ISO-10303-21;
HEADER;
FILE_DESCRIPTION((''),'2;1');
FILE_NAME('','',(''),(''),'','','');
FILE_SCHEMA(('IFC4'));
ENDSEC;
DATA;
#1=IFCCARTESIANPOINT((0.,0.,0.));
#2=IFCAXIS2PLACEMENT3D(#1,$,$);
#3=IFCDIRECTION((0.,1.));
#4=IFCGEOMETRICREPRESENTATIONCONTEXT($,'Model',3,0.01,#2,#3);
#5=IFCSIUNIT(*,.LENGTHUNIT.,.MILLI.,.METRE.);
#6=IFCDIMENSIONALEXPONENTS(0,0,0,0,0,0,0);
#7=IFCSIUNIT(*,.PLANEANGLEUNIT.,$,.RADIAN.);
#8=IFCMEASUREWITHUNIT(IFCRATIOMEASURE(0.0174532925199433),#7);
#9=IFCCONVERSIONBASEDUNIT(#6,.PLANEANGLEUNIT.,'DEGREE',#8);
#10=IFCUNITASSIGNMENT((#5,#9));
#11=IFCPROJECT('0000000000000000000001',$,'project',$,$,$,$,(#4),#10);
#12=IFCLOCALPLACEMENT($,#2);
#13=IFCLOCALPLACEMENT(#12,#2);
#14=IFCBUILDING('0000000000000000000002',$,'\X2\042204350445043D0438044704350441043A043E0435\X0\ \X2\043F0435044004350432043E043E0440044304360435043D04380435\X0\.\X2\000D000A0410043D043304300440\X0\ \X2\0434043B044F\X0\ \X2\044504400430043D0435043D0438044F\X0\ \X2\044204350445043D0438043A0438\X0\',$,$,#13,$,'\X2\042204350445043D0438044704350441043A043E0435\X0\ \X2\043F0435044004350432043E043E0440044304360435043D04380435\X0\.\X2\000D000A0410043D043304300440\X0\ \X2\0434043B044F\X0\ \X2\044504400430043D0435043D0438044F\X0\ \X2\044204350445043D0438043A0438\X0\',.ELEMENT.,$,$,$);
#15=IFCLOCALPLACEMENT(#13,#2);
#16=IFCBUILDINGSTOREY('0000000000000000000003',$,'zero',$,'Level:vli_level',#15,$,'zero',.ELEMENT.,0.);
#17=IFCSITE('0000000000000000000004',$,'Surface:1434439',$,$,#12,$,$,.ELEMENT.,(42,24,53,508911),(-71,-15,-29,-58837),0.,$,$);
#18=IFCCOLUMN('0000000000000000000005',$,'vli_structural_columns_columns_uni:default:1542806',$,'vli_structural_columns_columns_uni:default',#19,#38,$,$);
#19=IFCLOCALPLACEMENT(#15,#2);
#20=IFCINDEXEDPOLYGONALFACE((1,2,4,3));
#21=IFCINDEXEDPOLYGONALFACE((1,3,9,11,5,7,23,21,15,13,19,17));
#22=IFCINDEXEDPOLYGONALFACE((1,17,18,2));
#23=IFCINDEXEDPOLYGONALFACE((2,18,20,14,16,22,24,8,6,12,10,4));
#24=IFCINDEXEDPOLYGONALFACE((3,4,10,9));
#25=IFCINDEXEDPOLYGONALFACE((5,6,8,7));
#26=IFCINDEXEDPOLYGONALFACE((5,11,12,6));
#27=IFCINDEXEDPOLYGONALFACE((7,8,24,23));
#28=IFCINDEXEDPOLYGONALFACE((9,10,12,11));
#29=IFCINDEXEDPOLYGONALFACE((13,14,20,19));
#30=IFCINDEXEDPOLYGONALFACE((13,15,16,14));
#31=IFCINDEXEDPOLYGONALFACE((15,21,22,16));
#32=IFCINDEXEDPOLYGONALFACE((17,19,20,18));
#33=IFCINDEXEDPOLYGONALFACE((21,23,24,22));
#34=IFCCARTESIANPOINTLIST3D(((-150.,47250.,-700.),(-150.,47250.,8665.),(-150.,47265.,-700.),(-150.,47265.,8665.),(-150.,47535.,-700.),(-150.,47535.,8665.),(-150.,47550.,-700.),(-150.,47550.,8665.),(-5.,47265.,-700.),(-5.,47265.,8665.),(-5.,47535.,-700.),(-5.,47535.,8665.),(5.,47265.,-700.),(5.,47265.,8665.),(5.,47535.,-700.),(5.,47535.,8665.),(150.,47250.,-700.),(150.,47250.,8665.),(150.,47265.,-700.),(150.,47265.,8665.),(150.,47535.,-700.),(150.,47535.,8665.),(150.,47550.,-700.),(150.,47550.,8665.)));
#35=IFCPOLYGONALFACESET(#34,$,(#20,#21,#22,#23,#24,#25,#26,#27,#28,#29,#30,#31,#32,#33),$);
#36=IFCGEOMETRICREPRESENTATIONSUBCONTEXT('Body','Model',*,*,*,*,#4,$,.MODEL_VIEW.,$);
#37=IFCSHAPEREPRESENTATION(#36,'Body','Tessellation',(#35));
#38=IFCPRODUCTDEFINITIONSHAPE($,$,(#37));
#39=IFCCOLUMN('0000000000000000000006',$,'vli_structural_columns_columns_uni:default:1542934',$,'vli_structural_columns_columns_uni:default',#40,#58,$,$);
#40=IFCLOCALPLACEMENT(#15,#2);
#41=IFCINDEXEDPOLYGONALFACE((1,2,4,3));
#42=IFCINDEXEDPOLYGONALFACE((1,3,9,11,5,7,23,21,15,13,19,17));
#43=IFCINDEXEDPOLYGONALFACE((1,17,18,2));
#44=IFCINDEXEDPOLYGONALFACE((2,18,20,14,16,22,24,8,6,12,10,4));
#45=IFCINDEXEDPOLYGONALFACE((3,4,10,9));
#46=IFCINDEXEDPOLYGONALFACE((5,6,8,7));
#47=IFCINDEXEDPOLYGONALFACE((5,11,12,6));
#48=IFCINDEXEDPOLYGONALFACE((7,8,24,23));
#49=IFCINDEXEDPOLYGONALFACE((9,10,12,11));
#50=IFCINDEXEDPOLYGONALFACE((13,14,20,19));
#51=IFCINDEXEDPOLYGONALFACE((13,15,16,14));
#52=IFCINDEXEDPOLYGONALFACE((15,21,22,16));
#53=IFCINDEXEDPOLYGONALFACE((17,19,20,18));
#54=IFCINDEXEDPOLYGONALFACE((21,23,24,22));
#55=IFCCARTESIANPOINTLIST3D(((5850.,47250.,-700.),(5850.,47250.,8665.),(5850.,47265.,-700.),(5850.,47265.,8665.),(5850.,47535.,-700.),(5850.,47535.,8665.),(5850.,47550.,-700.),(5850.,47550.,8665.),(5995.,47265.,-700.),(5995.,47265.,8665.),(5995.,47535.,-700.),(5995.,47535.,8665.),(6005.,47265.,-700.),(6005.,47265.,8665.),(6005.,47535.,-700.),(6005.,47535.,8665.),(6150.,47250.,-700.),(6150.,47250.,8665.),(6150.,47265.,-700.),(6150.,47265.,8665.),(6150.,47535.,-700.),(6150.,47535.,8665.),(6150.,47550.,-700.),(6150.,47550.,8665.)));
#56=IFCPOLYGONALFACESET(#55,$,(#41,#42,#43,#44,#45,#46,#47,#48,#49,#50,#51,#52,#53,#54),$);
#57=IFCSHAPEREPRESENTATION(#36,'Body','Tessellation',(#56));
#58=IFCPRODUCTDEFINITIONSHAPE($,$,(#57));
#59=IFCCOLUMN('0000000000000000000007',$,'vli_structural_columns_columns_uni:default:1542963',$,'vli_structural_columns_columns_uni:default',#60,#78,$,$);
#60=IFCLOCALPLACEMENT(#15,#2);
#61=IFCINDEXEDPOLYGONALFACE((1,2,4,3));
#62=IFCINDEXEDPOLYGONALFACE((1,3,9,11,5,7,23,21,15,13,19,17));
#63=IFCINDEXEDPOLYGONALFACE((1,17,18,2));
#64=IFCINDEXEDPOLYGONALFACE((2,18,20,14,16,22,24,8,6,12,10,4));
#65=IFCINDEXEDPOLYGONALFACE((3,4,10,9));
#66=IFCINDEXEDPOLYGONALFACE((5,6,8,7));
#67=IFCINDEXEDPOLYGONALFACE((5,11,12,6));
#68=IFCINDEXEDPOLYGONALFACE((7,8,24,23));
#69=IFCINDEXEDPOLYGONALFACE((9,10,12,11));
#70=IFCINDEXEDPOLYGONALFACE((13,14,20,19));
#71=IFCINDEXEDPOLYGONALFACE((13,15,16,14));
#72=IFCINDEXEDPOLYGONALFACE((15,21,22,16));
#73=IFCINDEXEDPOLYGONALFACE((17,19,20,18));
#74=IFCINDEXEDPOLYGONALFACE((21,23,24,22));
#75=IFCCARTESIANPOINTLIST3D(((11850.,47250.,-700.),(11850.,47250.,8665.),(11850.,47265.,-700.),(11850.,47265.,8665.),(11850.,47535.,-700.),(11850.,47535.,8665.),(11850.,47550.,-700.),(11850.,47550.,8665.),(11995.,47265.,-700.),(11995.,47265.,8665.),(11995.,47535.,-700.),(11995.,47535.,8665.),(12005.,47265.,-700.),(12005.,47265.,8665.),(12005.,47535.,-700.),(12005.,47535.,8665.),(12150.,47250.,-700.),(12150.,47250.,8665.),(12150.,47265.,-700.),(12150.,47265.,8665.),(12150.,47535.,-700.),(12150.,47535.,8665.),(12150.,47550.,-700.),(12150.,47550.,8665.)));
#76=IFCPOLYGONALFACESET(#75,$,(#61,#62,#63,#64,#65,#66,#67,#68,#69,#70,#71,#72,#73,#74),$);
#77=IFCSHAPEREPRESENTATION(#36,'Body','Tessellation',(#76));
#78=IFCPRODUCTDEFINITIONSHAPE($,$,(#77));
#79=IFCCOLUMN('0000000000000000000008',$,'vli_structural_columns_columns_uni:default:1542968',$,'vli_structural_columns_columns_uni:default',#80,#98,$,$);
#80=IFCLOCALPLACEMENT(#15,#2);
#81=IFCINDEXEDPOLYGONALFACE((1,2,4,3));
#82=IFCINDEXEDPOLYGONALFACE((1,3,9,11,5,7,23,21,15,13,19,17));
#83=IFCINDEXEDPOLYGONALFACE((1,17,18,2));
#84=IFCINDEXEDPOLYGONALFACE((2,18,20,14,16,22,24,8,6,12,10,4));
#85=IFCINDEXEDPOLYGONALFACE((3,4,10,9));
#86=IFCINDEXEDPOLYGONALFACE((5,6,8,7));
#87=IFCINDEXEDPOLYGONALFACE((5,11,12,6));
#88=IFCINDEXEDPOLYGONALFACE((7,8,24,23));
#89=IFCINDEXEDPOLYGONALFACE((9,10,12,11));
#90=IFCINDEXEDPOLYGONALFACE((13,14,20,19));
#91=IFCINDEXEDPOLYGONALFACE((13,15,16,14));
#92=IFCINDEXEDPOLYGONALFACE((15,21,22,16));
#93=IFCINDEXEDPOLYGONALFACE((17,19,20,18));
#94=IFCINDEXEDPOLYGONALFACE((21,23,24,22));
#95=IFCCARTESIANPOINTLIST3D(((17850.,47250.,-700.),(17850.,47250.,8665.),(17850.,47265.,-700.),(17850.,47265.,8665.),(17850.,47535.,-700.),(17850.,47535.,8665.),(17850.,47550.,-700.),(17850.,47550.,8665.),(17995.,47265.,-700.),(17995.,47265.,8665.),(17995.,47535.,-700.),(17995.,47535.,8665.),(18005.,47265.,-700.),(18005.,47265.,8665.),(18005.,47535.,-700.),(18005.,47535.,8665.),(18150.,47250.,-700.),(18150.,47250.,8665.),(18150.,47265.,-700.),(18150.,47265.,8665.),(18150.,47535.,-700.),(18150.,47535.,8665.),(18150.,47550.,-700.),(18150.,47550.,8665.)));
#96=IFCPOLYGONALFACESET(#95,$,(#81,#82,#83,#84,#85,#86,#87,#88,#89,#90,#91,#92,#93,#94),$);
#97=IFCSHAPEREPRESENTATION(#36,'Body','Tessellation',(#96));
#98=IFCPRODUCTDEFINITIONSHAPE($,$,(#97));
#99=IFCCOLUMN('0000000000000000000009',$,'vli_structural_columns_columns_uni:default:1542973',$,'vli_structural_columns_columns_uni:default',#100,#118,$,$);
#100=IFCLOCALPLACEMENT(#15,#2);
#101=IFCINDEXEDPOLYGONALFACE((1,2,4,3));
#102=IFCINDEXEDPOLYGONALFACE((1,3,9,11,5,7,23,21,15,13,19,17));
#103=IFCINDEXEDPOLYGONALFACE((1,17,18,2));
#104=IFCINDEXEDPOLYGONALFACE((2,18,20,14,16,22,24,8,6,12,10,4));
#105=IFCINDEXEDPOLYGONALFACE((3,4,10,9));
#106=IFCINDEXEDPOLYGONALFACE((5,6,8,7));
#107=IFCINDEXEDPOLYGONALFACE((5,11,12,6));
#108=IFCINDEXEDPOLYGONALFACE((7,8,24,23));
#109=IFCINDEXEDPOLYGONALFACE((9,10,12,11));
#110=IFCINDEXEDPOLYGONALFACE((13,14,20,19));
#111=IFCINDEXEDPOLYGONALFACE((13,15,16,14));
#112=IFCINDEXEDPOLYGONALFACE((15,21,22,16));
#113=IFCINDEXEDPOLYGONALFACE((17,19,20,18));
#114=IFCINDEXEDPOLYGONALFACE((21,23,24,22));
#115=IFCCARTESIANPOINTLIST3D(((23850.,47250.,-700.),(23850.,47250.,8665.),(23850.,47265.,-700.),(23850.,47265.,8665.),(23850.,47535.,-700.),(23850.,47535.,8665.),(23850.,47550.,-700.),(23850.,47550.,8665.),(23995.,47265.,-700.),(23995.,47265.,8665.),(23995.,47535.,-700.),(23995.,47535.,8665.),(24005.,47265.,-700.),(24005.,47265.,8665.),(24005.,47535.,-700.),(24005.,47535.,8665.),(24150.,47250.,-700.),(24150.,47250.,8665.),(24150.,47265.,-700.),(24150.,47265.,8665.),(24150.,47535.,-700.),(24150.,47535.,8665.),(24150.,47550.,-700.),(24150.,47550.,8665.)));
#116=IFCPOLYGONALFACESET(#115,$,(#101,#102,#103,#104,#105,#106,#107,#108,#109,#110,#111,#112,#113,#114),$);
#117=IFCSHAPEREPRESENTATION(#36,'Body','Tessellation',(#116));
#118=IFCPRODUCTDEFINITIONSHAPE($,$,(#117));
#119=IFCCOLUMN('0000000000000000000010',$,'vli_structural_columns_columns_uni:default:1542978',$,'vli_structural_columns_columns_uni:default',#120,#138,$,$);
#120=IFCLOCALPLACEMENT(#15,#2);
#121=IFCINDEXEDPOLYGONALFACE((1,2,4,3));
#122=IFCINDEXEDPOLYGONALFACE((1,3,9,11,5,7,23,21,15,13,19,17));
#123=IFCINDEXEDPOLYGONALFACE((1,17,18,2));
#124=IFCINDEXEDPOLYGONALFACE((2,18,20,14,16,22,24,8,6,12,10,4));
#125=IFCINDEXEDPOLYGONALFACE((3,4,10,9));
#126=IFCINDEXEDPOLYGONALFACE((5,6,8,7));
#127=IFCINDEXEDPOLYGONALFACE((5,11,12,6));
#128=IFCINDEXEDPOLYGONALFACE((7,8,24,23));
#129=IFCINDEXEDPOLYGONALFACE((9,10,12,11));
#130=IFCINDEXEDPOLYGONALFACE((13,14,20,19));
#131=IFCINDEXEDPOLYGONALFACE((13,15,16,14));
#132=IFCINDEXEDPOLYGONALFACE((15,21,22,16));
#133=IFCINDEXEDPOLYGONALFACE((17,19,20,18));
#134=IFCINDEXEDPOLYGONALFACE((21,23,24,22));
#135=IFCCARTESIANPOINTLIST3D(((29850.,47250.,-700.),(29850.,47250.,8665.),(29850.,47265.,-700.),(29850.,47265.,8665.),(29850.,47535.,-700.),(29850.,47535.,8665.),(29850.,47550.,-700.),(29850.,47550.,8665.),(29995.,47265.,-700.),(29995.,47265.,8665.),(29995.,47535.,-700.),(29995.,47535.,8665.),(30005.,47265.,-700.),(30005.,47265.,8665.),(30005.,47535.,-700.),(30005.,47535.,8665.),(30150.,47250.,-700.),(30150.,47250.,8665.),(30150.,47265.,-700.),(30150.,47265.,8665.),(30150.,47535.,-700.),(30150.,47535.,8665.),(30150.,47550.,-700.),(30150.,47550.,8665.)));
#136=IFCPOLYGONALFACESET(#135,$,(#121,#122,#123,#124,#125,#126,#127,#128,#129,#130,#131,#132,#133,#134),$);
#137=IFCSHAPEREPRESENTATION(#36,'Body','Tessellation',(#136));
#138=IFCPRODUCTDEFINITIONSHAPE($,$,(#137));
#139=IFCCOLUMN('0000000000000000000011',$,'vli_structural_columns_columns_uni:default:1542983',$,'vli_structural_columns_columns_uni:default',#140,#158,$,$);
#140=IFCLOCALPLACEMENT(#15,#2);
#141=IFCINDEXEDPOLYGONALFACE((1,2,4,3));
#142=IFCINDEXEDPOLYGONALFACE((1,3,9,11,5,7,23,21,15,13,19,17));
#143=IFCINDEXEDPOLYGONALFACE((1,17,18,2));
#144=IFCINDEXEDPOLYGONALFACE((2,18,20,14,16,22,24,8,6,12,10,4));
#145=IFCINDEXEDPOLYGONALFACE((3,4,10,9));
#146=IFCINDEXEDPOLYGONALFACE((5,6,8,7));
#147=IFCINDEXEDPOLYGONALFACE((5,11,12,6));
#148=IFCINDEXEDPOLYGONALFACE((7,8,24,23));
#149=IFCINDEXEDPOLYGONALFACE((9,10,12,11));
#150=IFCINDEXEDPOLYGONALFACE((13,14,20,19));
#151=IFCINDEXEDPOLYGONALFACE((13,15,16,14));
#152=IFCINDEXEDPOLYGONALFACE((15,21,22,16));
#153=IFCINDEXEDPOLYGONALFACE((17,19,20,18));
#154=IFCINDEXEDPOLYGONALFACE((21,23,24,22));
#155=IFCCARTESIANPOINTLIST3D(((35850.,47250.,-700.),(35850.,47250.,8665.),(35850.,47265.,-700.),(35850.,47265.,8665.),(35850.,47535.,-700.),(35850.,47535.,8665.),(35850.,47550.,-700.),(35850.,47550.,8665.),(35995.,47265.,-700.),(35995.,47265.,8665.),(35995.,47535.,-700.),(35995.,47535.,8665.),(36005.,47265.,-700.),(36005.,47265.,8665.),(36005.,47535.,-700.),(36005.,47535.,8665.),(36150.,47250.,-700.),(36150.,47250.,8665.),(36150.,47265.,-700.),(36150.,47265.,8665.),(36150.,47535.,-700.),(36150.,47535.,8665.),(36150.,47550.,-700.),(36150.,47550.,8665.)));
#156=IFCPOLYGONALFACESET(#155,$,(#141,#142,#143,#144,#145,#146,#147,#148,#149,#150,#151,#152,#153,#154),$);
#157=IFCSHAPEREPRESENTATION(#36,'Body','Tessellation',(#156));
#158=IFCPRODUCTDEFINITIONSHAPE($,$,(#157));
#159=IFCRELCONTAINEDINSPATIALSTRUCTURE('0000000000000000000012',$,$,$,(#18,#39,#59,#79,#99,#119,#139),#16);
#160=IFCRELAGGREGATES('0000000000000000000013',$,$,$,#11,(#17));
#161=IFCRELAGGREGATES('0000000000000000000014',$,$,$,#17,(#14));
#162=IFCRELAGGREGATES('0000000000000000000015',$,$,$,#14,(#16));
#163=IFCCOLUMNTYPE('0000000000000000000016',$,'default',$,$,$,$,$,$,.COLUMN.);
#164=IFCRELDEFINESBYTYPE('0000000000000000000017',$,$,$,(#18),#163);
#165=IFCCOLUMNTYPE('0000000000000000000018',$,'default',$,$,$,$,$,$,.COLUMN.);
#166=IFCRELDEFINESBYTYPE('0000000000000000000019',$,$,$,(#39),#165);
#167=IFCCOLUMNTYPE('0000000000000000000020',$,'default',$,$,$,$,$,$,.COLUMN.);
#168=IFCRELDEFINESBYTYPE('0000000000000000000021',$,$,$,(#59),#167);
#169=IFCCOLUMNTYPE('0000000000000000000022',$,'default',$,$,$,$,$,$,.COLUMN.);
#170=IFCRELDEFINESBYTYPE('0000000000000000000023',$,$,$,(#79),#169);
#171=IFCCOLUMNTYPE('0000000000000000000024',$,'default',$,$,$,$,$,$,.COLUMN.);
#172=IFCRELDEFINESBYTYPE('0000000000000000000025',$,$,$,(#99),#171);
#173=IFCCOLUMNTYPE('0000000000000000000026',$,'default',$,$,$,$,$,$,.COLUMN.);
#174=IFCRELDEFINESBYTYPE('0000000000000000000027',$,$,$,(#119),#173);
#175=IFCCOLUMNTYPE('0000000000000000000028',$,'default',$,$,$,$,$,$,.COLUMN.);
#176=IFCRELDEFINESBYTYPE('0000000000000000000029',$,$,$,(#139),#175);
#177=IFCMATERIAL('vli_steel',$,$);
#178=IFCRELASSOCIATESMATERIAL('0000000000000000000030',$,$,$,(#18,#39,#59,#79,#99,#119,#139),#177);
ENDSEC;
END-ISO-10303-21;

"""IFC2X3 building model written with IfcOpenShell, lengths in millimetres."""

from ifc_helpers import new_model, entity, si_unit, converted_unit, direction, frame, origin, place, context, subcontext, project, spatial, polyline, outline, extrude, source, transform, mapped, material, type_object, type_shapes, element, save


model = new_model("IFC2X3")

# Units and contexts
model_context = context("Model", 3, precision=0.01, world=origin(), true_north=direction((0.0, 1.0)))
body_context = subcontext(model_context, "Body", "Model", "MODEL_VIEW")
ifc_project = project(units=[si_unit("LENGTHUNIT", "METRE", prefix="MILLI"), converted_unit("PLANEANGLEUNIT", "DEGREE", entity("IfcRatioMeasure", 0.0174532925199433), si_unit("PLANEANGLEUNIT", "RADIAN"), dimensions=[0, 0, 0, 0, 0, 0, 0])], contexts=[model_context])

# Site, building, storey
site_placement = place(None, origin())
site = spatial("IfcSite", under=ifc_project, at=site_placement, Name="Surface:1434439", CompositionType="ELEMENT", RefLatitude=(42, 24, 53, 508911), RefLongitude=(-71, -15, -29, -58837), RefElevation=0.0)
building_placement = place(site_placement, origin())
building = spatial("IfcBuilding", under=site, at=building_placement, Name="Техническое перевооружение.\r\nАнгар для хранения техники", LongName="Техническое перевооружение.\r\nАнгар для хранения техники", CompositionType="ELEMENT")
storey_placement = place(building_placement, origin())
storey = spatial("IfcBuildingStorey", under=building, at=storey_placement, Name="zero", ObjectType="Level:vli_level", LongName="zero", CompositionType="ELEMENT", Elevation=0.0)

# Columns
ifc_material_1 = material(Name="vli_steel")
column_type_1 = type_object("IfcColumnType", Name="default", PredefinedType="COLUMN")
shared_shape_1 = source(origin(), body_context, "Body", "SweptSolid", [
    extrude(outline(polyline([(135.0, -150.0), (150.0, -150.0), (150.0, 150.0), (135.0, 150.0), (135.0, 5.0), (-135.0, 5.0), (-135.0, 150.0), (-150.0, 150.0), (-150.0, -150.0), (-135.0, -150.0), (-135.0, -5.0), (135.0, -5.0), (135.0, -150.0)])), frame((0.0, 47400.0, -700.0), z_axis=(0.0, 0.0, 1.0), x_axis=(0.0, -1.0, 0.0)), (0.0, 0.0, 1.0), 9365.0),
])
type_shapes(column_type_1, [shared_shape_1])
column_1_placement = place(storey_placement, origin())
element("IfcColumn", 1, at=column_1_placement, inside=storey, type_object=column_type_1, material=ifc_material_1, Name="vli_structural_columns_columns_uni:default:1542806", ObjectType="vli_structural_columns_columns_uni:default", context=body_context, shape_type="MappedRepresentation", body=[
    mapped(shared_shape_1, transform((0.0, 0.0, 0.0), scale=1.0)),
])
column_type_2 = type_object("IfcColumnType", Name="default", PredefinedType="COLUMN")
shared_shape_2 = source(origin(), body_context, "Body", "SweptSolid", [
    extrude(outline(polyline([(135.0, -150.0), (150.0, -150.0), (150.0, 150.0), (135.0, 150.0), (135.0, 5.0), (-135.0, 5.0), (-135.0, 150.0), (-150.0, 150.0), (-150.0, -150.0), (-135.0, -150.0), (-135.0, -5.0), (135.0, -5.0), (135.0, -150.0)])), frame((6000.0, 47400.0, -700.0), z_axis=(0.0, 0.0, 1.0), x_axis=(0.0, -1.0, 0.0)), (0.0, 0.0, 1.0), 9365.0),
])
type_shapes(column_type_2, [shared_shape_2])
column_2_placement = place(storey_placement, origin())
element("IfcColumn", 2, at=column_2_placement, inside=storey, type_object=column_type_2, material=ifc_material_1, Name="vli_structural_columns_columns_uni:default:1542934", ObjectType="vli_structural_columns_columns_uni:default", context=body_context, shape_type="MappedRepresentation", body=[
    mapped(shared_shape_2, transform((0.0, 0.0, 0.0), scale=1.0)),
])
column_type_3 = type_object("IfcColumnType", Name="default", PredefinedType="COLUMN")
shared_shape_3 = source(origin(), body_context, "Body", "SweptSolid", [
    extrude(outline(polyline([(135.0, -150.0), (150.0, -150.0), (150.0, 150.0), (135.0, 150.0), (135.0, 5.0), (-135.0, 5.0), (-135.0, 150.0), (-150.0, 150.0), (-150.0, -150.0), (-135.0, -150.0), (-135.0, -5.0), (135.0, -5.0), (135.0, -150.0)])), frame((12000.0, 47400.0, -700.0), z_axis=(0.0, 0.0, 1.0), x_axis=(0.0, -1.0, 0.0)), (0.0, 0.0, 1.0), 9365.0),
])
type_shapes(column_type_3, [shared_shape_3])
column_3_placement = place(storey_placement, origin())
element("IfcColumn", 3, at=column_3_placement, inside=storey, type_object=column_type_3, material=ifc_material_1, Name="vli_structural_columns_columns_uni:default:1542963", ObjectType="vli_structural_columns_columns_uni:default", context=body_context, shape_type="MappedRepresentation", body=[
    mapped(shared_shape_3, transform((0.0, 0.0, 0.0), scale=1.0)),
])
column_type_4 = type_object("IfcColumnType", Name="default", PredefinedType="COLUMN")
shared_shape_4 = source(origin(), body_context, "Body", "SweptSolid", [
    extrude(outline(polyline([(135.0, -150.0), (150.0, -150.0), (150.0, 150.0), (135.0, 150.0), (135.0, 5.0), (-135.0, 5.0), (-135.0, 150.0), (-150.0, 150.0), (-150.0, -150.0), (-135.0, -150.0), (-135.0, -5.0), (135.0, -5.0), (135.0, -150.0)])), frame((18000.0, 47400.0, -700.0), z_axis=(0.0, 0.0, 1.0), x_axis=(0.0, -1.0, 0.0)), (0.0, 0.0, 1.0), 9365.0),
])
type_shapes(column_type_4, [shared_shape_4])
column_4_placement = place(storey_placement, origin())
element("IfcColumn", 4, at=column_4_placement, inside=storey, type_object=column_type_4, material=ifc_material_1, Name="vli_structural_columns_columns_uni:default:1542968", ObjectType="vli_structural_columns_columns_uni:default", context=body_context, shape_type="MappedRepresentation", body=[
    mapped(shared_shape_4, transform((0.0, 0.0, 0.0), scale=1.0)),
])
column_type_5 = type_object("IfcColumnType", Name="default", PredefinedType="COLUMN")
shared_shape_5 = source(origin(), body_context, "Body", "SweptSolid", [
    extrude(outline(polyline([(135.0, -150.0), (150.0, -150.0), (150.0, 150.0), (135.0, 150.0), (135.0, 5.0), (-135.0, 5.0), (-135.0, 150.0), (-150.0, 150.0), (-150.0, -150.0), (-135.0, -150.0), (-135.0, -5.0), (135.0, -5.0), (135.0, -150.0)])), frame((24000.0, 47400.0, -700.0), z_axis=(0.0, 0.0, 1.0), x_axis=(0.0, -1.0, 0.0)), (0.0, 0.0, 1.0), 9365.0),
])
type_shapes(column_type_5, [shared_shape_5])
column_5_placement = place(storey_placement, origin())
element("IfcColumn", 5, at=column_5_placement, inside=storey, type_object=column_type_5, material=ifc_material_1, Name="vli_structural_columns_columns_uni:default:1542973", ObjectType="vli_structural_columns_columns_uni:default", context=body_context, shape_type="MappedRepresentation", body=[
    mapped(shared_shape_5, transform((0.0, 0.0, 0.0), scale=1.0)),
])
column_type_6 = type_object("IfcColumnType", Name="default", PredefinedType="COLUMN")
shared_shape_6 = source(origin(), body_context, "Body", "SweptSolid", [
    extrude(outline(polyline([(135.0, -150.0), (150.0, -150.0), (150.0, 150.0), (135.0, 150.0), (135.0, 5.0), (-135.0, 5.0), (-135.0, 150.0), (-150.0, 150.0), (-150.0, -150.0), (-135.0, -150.0), (-135.0, -5.0), (135.0, -5.0), (135.0, -150.0)])), frame((30000.0, 47400.0, -700.0), z_axis=(0.0, 0.0, 1.0), x_axis=(0.0, -1.0, 0.0)), (0.0, 0.0, 1.0), 9365.0),
])
type_shapes(column_type_6, [shared_shape_6])
column_6_placement = place(storey_placement, origin())
element("IfcColumn", 6, at=column_6_placement, inside=storey, type_object=column_type_6, material=ifc_material_1, Name="vli_structural_columns_columns_uni:default:1542978", ObjectType="vli_structural_columns_columns_uni:default", context=body_context, shape_type="MappedRepresentation", body=[
    mapped(shared_shape_6, transform((0.0, 0.0, 0.0), scale=1.0)),
])
column_type_7 = type_object("IfcColumnType", Name="default", PredefinedType="COLUMN")
shared_shape_7 = source(origin(), body_context, "Body", "SweptSolid", [
    extrude(outline(polyline([(135.0, -150.0), (150.0, -150.0), (150.0, 150.0), (135.0, 150.0), (135.0, 5.0), (-135.0, 5.0), (-135.0, 150.0), (-150.0, 150.0), (-150.0, -150.0), (-135.0, -150.0), (-135.0, -5.0), (135.0, -5.0), (135.0, -150.0)])), frame((36000.0, 47400.0, -700.0), z_axis=(0.0, 0.0, 1.0), x_axis=(0.0, -1.0, 0.0)), (0.0, 0.0, 1.0), 9365.0),
])
type_shapes(column_type_7, [shared_shape_7])
column_7_placement = place(storey_placement, origin())
element("IfcColumn", 7, at=column_7_placement, inside=storey, type_object=column_type_7, material=ifc_material_1, Name="vli_structural_columns_columns_uni:default:1542983", ObjectType="vli_structural_columns_columns_uni:default", context=body_context, shape_type="MappedRepresentation", body=[
    mapped(shared_shape_7, transform((0.0, 0.0, 0.0), scale=1.0)),
])

save(model, "model.ifc")
